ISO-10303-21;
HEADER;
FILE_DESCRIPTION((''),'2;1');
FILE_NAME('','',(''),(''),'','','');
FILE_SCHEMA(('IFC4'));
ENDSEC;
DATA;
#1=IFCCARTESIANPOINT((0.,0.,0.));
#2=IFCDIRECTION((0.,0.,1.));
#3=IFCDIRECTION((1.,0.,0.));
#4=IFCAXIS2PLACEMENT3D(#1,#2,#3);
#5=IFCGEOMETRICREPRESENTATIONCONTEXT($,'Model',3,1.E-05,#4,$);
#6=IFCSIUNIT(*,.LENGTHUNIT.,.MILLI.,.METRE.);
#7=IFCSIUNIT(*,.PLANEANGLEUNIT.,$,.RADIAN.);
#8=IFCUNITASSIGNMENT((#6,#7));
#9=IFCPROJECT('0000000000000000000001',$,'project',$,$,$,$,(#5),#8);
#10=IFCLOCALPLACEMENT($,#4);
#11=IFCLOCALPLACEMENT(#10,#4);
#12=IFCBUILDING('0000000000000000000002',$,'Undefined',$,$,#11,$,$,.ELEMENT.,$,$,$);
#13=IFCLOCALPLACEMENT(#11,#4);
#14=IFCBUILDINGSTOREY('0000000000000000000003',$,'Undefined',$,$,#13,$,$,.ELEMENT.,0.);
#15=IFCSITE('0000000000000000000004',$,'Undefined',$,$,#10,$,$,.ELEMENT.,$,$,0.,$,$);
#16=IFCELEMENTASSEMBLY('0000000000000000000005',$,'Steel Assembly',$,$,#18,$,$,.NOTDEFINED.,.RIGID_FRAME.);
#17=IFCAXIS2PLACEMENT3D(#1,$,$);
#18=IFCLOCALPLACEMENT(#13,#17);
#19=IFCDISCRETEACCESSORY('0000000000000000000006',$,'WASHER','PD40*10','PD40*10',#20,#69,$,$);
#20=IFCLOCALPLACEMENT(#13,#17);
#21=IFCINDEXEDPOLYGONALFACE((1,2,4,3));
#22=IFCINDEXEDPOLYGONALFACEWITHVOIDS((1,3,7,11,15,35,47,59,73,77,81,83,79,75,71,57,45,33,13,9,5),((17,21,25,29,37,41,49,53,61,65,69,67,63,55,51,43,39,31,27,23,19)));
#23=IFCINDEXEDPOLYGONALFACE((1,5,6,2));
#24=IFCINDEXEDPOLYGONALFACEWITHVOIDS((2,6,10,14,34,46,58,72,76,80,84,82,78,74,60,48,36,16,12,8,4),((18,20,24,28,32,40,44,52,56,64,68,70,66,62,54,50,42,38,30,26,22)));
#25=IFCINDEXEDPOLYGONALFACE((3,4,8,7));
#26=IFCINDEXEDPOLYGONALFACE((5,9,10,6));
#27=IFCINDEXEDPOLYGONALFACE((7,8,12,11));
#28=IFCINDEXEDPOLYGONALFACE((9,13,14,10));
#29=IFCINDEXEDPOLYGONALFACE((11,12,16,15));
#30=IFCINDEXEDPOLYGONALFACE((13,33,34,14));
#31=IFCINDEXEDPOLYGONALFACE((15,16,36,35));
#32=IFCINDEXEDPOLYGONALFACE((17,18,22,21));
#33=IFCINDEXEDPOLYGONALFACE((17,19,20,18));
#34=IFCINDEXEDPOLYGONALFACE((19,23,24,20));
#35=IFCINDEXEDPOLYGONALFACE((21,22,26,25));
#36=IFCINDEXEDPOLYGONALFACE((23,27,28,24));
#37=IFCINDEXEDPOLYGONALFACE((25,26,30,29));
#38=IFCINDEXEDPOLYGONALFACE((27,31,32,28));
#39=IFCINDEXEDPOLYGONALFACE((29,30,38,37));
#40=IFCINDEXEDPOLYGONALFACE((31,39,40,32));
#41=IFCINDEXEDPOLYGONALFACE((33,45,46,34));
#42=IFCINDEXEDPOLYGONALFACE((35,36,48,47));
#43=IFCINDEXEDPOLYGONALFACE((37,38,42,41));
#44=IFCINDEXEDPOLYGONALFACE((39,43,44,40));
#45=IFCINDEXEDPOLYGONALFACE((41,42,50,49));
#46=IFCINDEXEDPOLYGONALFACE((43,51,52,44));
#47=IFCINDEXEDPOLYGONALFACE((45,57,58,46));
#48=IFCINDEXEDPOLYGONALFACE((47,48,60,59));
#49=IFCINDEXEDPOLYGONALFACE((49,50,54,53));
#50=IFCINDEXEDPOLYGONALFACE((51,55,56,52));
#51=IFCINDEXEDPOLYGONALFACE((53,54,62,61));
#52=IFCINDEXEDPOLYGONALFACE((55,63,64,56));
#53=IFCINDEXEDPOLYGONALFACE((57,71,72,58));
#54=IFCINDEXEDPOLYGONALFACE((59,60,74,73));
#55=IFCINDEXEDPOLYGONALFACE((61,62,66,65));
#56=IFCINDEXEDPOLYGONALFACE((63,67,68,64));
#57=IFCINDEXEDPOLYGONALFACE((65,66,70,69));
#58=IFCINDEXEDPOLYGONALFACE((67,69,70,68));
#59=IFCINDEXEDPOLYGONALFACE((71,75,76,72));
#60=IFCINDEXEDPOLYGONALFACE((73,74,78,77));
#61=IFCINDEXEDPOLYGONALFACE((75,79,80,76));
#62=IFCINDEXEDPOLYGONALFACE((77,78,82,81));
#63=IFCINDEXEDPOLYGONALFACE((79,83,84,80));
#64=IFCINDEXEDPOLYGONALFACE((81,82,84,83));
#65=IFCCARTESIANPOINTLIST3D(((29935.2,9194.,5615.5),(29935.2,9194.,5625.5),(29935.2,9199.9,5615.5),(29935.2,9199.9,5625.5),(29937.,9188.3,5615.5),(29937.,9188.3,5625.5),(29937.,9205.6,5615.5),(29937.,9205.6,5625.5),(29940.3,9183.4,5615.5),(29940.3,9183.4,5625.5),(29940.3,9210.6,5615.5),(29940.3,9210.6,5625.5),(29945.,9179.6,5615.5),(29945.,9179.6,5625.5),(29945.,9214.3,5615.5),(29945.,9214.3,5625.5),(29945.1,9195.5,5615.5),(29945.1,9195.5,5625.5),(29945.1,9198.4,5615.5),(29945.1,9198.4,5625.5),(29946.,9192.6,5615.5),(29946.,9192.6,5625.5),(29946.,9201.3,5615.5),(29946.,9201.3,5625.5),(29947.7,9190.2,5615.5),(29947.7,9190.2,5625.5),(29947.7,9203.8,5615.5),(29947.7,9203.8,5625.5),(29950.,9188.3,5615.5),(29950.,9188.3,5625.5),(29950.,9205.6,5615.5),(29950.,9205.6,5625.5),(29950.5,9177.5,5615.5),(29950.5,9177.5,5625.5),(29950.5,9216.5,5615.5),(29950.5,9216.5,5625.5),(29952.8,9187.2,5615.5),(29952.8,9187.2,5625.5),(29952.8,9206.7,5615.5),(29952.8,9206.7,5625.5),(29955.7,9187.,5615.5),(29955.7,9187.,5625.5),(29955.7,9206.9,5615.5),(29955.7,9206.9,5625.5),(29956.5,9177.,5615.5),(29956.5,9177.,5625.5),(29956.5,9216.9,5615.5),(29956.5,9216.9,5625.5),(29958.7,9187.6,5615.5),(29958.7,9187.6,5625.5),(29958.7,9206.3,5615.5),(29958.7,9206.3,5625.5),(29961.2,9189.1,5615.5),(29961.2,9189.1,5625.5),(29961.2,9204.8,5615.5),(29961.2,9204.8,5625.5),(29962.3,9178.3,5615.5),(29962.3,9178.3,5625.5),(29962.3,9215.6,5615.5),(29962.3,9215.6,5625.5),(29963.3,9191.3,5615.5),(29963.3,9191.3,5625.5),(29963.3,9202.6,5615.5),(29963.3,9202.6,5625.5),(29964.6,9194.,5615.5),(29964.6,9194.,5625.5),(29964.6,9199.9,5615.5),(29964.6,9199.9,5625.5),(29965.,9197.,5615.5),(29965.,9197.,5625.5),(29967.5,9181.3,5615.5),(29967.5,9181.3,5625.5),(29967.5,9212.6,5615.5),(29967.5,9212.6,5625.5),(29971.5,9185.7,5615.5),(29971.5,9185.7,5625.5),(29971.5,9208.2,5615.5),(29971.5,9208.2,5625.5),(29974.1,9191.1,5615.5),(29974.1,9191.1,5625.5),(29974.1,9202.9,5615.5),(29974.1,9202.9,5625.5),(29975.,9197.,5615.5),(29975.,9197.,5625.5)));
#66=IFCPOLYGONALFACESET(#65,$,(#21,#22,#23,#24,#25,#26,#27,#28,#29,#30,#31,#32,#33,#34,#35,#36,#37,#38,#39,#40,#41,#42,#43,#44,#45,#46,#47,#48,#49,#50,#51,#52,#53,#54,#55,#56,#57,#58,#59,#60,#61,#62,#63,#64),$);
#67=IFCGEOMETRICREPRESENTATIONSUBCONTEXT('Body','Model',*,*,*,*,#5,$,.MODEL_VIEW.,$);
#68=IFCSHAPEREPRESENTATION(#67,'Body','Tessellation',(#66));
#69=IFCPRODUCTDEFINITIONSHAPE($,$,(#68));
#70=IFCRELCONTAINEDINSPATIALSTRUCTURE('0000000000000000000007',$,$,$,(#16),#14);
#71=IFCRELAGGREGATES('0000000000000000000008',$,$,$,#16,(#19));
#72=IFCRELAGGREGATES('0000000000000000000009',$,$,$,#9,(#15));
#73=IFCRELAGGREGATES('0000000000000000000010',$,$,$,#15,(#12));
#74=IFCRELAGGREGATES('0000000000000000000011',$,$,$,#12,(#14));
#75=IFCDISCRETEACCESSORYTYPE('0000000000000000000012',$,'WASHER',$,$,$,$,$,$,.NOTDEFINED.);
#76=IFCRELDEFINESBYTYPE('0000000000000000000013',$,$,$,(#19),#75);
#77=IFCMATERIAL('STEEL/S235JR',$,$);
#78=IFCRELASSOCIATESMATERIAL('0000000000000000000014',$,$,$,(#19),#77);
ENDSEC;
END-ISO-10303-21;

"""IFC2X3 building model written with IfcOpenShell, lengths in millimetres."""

from ifc_helpers import new_model, si_unit, frame, origin_with_axes, origin_2d_with_axis, place, context, subcontext, project, spatial, hollow_circle, extrude, material, type_object, element, aggregate, save


model = new_model("IFC2X3")

# Units and contexts
model_context = context("Model", 3, precision=1e-05, world=origin_with_axes())
body_context = subcontext(model_context, "Body", "Model", "MODEL_VIEW")
ifc_project = project(units=[si_unit("LENGTHUNIT", "METRE", prefix="MILLI"), si_unit("PLANEANGLEUNIT", "RADIAN")], contexts=[model_context])

# Site, building, storey
site_placement = place(None, origin_with_axes())
site = spatial("IfcSite", under=ifc_project, at=site_placement, Name="Undefined", CompositionType="ELEMENT", RefElevation=0.0)
building_placement = place(site_placement, origin_with_axes())
building = spatial("IfcBuilding", under=site, at=building_placement, Name="Undefined", CompositionType="ELEMENT")
storey_placement = place(building_placement, origin_with_axes())
storey = spatial("IfcBuildingStorey", under=building, at=storey_placement, Name="Undefined", CompositionType="ELEMENT", Elevation=0.0)

# Shared definitions
ifc_material_1 = material(Name="STEEL/S235JR")

# Element assembly
assembly_1_placement = place(storey_placement, origin_with_axes())
assembly_1 = element("IfcElementAssembly", 1, at=assembly_1_placement, inside=storey, Name="Steel Assembly", AssemblyPlace="NOTDEFINED", PredefinedType="RIGID_FRAME")

# Discrete accessory
discrete_accessory_type_1 = type_object("IfcDiscreteAccessoryType", Name="WASHER")
discrete_accessory_1_placement = place(assembly_1_placement, frame((29955.0, 9197.0, 5625.5), z_axis=(0.0, 1.0, 0.0), x_axis=(0.0, 0.0, -1.0)))
discrete_accessory_1 = element("IfcDiscreteAccessory", 2, at=discrete_accessory_1_placement, type_object=discrete_accessory_type_1, material=ifc_material_1, Name="WASHER", Description="PD40*10", ObjectType="PD40*10", context=body_context, shape_type="SweptSolid", body=[
    extrude(hollow_circle(Radius=20.0, WallThickness=10.0, at=origin_2d_with_axis()), frame((10.0, 0.0, 0.0), z_axis=(-1.0, 0.0, 0.0), x_axis=(0.0, -1.0, 0.0)), (0.0, 0.0, 1.0), 10.0),
])
aggregate(assembly_1, [discrete_accessory_1])

save(model, "model.ifc")
